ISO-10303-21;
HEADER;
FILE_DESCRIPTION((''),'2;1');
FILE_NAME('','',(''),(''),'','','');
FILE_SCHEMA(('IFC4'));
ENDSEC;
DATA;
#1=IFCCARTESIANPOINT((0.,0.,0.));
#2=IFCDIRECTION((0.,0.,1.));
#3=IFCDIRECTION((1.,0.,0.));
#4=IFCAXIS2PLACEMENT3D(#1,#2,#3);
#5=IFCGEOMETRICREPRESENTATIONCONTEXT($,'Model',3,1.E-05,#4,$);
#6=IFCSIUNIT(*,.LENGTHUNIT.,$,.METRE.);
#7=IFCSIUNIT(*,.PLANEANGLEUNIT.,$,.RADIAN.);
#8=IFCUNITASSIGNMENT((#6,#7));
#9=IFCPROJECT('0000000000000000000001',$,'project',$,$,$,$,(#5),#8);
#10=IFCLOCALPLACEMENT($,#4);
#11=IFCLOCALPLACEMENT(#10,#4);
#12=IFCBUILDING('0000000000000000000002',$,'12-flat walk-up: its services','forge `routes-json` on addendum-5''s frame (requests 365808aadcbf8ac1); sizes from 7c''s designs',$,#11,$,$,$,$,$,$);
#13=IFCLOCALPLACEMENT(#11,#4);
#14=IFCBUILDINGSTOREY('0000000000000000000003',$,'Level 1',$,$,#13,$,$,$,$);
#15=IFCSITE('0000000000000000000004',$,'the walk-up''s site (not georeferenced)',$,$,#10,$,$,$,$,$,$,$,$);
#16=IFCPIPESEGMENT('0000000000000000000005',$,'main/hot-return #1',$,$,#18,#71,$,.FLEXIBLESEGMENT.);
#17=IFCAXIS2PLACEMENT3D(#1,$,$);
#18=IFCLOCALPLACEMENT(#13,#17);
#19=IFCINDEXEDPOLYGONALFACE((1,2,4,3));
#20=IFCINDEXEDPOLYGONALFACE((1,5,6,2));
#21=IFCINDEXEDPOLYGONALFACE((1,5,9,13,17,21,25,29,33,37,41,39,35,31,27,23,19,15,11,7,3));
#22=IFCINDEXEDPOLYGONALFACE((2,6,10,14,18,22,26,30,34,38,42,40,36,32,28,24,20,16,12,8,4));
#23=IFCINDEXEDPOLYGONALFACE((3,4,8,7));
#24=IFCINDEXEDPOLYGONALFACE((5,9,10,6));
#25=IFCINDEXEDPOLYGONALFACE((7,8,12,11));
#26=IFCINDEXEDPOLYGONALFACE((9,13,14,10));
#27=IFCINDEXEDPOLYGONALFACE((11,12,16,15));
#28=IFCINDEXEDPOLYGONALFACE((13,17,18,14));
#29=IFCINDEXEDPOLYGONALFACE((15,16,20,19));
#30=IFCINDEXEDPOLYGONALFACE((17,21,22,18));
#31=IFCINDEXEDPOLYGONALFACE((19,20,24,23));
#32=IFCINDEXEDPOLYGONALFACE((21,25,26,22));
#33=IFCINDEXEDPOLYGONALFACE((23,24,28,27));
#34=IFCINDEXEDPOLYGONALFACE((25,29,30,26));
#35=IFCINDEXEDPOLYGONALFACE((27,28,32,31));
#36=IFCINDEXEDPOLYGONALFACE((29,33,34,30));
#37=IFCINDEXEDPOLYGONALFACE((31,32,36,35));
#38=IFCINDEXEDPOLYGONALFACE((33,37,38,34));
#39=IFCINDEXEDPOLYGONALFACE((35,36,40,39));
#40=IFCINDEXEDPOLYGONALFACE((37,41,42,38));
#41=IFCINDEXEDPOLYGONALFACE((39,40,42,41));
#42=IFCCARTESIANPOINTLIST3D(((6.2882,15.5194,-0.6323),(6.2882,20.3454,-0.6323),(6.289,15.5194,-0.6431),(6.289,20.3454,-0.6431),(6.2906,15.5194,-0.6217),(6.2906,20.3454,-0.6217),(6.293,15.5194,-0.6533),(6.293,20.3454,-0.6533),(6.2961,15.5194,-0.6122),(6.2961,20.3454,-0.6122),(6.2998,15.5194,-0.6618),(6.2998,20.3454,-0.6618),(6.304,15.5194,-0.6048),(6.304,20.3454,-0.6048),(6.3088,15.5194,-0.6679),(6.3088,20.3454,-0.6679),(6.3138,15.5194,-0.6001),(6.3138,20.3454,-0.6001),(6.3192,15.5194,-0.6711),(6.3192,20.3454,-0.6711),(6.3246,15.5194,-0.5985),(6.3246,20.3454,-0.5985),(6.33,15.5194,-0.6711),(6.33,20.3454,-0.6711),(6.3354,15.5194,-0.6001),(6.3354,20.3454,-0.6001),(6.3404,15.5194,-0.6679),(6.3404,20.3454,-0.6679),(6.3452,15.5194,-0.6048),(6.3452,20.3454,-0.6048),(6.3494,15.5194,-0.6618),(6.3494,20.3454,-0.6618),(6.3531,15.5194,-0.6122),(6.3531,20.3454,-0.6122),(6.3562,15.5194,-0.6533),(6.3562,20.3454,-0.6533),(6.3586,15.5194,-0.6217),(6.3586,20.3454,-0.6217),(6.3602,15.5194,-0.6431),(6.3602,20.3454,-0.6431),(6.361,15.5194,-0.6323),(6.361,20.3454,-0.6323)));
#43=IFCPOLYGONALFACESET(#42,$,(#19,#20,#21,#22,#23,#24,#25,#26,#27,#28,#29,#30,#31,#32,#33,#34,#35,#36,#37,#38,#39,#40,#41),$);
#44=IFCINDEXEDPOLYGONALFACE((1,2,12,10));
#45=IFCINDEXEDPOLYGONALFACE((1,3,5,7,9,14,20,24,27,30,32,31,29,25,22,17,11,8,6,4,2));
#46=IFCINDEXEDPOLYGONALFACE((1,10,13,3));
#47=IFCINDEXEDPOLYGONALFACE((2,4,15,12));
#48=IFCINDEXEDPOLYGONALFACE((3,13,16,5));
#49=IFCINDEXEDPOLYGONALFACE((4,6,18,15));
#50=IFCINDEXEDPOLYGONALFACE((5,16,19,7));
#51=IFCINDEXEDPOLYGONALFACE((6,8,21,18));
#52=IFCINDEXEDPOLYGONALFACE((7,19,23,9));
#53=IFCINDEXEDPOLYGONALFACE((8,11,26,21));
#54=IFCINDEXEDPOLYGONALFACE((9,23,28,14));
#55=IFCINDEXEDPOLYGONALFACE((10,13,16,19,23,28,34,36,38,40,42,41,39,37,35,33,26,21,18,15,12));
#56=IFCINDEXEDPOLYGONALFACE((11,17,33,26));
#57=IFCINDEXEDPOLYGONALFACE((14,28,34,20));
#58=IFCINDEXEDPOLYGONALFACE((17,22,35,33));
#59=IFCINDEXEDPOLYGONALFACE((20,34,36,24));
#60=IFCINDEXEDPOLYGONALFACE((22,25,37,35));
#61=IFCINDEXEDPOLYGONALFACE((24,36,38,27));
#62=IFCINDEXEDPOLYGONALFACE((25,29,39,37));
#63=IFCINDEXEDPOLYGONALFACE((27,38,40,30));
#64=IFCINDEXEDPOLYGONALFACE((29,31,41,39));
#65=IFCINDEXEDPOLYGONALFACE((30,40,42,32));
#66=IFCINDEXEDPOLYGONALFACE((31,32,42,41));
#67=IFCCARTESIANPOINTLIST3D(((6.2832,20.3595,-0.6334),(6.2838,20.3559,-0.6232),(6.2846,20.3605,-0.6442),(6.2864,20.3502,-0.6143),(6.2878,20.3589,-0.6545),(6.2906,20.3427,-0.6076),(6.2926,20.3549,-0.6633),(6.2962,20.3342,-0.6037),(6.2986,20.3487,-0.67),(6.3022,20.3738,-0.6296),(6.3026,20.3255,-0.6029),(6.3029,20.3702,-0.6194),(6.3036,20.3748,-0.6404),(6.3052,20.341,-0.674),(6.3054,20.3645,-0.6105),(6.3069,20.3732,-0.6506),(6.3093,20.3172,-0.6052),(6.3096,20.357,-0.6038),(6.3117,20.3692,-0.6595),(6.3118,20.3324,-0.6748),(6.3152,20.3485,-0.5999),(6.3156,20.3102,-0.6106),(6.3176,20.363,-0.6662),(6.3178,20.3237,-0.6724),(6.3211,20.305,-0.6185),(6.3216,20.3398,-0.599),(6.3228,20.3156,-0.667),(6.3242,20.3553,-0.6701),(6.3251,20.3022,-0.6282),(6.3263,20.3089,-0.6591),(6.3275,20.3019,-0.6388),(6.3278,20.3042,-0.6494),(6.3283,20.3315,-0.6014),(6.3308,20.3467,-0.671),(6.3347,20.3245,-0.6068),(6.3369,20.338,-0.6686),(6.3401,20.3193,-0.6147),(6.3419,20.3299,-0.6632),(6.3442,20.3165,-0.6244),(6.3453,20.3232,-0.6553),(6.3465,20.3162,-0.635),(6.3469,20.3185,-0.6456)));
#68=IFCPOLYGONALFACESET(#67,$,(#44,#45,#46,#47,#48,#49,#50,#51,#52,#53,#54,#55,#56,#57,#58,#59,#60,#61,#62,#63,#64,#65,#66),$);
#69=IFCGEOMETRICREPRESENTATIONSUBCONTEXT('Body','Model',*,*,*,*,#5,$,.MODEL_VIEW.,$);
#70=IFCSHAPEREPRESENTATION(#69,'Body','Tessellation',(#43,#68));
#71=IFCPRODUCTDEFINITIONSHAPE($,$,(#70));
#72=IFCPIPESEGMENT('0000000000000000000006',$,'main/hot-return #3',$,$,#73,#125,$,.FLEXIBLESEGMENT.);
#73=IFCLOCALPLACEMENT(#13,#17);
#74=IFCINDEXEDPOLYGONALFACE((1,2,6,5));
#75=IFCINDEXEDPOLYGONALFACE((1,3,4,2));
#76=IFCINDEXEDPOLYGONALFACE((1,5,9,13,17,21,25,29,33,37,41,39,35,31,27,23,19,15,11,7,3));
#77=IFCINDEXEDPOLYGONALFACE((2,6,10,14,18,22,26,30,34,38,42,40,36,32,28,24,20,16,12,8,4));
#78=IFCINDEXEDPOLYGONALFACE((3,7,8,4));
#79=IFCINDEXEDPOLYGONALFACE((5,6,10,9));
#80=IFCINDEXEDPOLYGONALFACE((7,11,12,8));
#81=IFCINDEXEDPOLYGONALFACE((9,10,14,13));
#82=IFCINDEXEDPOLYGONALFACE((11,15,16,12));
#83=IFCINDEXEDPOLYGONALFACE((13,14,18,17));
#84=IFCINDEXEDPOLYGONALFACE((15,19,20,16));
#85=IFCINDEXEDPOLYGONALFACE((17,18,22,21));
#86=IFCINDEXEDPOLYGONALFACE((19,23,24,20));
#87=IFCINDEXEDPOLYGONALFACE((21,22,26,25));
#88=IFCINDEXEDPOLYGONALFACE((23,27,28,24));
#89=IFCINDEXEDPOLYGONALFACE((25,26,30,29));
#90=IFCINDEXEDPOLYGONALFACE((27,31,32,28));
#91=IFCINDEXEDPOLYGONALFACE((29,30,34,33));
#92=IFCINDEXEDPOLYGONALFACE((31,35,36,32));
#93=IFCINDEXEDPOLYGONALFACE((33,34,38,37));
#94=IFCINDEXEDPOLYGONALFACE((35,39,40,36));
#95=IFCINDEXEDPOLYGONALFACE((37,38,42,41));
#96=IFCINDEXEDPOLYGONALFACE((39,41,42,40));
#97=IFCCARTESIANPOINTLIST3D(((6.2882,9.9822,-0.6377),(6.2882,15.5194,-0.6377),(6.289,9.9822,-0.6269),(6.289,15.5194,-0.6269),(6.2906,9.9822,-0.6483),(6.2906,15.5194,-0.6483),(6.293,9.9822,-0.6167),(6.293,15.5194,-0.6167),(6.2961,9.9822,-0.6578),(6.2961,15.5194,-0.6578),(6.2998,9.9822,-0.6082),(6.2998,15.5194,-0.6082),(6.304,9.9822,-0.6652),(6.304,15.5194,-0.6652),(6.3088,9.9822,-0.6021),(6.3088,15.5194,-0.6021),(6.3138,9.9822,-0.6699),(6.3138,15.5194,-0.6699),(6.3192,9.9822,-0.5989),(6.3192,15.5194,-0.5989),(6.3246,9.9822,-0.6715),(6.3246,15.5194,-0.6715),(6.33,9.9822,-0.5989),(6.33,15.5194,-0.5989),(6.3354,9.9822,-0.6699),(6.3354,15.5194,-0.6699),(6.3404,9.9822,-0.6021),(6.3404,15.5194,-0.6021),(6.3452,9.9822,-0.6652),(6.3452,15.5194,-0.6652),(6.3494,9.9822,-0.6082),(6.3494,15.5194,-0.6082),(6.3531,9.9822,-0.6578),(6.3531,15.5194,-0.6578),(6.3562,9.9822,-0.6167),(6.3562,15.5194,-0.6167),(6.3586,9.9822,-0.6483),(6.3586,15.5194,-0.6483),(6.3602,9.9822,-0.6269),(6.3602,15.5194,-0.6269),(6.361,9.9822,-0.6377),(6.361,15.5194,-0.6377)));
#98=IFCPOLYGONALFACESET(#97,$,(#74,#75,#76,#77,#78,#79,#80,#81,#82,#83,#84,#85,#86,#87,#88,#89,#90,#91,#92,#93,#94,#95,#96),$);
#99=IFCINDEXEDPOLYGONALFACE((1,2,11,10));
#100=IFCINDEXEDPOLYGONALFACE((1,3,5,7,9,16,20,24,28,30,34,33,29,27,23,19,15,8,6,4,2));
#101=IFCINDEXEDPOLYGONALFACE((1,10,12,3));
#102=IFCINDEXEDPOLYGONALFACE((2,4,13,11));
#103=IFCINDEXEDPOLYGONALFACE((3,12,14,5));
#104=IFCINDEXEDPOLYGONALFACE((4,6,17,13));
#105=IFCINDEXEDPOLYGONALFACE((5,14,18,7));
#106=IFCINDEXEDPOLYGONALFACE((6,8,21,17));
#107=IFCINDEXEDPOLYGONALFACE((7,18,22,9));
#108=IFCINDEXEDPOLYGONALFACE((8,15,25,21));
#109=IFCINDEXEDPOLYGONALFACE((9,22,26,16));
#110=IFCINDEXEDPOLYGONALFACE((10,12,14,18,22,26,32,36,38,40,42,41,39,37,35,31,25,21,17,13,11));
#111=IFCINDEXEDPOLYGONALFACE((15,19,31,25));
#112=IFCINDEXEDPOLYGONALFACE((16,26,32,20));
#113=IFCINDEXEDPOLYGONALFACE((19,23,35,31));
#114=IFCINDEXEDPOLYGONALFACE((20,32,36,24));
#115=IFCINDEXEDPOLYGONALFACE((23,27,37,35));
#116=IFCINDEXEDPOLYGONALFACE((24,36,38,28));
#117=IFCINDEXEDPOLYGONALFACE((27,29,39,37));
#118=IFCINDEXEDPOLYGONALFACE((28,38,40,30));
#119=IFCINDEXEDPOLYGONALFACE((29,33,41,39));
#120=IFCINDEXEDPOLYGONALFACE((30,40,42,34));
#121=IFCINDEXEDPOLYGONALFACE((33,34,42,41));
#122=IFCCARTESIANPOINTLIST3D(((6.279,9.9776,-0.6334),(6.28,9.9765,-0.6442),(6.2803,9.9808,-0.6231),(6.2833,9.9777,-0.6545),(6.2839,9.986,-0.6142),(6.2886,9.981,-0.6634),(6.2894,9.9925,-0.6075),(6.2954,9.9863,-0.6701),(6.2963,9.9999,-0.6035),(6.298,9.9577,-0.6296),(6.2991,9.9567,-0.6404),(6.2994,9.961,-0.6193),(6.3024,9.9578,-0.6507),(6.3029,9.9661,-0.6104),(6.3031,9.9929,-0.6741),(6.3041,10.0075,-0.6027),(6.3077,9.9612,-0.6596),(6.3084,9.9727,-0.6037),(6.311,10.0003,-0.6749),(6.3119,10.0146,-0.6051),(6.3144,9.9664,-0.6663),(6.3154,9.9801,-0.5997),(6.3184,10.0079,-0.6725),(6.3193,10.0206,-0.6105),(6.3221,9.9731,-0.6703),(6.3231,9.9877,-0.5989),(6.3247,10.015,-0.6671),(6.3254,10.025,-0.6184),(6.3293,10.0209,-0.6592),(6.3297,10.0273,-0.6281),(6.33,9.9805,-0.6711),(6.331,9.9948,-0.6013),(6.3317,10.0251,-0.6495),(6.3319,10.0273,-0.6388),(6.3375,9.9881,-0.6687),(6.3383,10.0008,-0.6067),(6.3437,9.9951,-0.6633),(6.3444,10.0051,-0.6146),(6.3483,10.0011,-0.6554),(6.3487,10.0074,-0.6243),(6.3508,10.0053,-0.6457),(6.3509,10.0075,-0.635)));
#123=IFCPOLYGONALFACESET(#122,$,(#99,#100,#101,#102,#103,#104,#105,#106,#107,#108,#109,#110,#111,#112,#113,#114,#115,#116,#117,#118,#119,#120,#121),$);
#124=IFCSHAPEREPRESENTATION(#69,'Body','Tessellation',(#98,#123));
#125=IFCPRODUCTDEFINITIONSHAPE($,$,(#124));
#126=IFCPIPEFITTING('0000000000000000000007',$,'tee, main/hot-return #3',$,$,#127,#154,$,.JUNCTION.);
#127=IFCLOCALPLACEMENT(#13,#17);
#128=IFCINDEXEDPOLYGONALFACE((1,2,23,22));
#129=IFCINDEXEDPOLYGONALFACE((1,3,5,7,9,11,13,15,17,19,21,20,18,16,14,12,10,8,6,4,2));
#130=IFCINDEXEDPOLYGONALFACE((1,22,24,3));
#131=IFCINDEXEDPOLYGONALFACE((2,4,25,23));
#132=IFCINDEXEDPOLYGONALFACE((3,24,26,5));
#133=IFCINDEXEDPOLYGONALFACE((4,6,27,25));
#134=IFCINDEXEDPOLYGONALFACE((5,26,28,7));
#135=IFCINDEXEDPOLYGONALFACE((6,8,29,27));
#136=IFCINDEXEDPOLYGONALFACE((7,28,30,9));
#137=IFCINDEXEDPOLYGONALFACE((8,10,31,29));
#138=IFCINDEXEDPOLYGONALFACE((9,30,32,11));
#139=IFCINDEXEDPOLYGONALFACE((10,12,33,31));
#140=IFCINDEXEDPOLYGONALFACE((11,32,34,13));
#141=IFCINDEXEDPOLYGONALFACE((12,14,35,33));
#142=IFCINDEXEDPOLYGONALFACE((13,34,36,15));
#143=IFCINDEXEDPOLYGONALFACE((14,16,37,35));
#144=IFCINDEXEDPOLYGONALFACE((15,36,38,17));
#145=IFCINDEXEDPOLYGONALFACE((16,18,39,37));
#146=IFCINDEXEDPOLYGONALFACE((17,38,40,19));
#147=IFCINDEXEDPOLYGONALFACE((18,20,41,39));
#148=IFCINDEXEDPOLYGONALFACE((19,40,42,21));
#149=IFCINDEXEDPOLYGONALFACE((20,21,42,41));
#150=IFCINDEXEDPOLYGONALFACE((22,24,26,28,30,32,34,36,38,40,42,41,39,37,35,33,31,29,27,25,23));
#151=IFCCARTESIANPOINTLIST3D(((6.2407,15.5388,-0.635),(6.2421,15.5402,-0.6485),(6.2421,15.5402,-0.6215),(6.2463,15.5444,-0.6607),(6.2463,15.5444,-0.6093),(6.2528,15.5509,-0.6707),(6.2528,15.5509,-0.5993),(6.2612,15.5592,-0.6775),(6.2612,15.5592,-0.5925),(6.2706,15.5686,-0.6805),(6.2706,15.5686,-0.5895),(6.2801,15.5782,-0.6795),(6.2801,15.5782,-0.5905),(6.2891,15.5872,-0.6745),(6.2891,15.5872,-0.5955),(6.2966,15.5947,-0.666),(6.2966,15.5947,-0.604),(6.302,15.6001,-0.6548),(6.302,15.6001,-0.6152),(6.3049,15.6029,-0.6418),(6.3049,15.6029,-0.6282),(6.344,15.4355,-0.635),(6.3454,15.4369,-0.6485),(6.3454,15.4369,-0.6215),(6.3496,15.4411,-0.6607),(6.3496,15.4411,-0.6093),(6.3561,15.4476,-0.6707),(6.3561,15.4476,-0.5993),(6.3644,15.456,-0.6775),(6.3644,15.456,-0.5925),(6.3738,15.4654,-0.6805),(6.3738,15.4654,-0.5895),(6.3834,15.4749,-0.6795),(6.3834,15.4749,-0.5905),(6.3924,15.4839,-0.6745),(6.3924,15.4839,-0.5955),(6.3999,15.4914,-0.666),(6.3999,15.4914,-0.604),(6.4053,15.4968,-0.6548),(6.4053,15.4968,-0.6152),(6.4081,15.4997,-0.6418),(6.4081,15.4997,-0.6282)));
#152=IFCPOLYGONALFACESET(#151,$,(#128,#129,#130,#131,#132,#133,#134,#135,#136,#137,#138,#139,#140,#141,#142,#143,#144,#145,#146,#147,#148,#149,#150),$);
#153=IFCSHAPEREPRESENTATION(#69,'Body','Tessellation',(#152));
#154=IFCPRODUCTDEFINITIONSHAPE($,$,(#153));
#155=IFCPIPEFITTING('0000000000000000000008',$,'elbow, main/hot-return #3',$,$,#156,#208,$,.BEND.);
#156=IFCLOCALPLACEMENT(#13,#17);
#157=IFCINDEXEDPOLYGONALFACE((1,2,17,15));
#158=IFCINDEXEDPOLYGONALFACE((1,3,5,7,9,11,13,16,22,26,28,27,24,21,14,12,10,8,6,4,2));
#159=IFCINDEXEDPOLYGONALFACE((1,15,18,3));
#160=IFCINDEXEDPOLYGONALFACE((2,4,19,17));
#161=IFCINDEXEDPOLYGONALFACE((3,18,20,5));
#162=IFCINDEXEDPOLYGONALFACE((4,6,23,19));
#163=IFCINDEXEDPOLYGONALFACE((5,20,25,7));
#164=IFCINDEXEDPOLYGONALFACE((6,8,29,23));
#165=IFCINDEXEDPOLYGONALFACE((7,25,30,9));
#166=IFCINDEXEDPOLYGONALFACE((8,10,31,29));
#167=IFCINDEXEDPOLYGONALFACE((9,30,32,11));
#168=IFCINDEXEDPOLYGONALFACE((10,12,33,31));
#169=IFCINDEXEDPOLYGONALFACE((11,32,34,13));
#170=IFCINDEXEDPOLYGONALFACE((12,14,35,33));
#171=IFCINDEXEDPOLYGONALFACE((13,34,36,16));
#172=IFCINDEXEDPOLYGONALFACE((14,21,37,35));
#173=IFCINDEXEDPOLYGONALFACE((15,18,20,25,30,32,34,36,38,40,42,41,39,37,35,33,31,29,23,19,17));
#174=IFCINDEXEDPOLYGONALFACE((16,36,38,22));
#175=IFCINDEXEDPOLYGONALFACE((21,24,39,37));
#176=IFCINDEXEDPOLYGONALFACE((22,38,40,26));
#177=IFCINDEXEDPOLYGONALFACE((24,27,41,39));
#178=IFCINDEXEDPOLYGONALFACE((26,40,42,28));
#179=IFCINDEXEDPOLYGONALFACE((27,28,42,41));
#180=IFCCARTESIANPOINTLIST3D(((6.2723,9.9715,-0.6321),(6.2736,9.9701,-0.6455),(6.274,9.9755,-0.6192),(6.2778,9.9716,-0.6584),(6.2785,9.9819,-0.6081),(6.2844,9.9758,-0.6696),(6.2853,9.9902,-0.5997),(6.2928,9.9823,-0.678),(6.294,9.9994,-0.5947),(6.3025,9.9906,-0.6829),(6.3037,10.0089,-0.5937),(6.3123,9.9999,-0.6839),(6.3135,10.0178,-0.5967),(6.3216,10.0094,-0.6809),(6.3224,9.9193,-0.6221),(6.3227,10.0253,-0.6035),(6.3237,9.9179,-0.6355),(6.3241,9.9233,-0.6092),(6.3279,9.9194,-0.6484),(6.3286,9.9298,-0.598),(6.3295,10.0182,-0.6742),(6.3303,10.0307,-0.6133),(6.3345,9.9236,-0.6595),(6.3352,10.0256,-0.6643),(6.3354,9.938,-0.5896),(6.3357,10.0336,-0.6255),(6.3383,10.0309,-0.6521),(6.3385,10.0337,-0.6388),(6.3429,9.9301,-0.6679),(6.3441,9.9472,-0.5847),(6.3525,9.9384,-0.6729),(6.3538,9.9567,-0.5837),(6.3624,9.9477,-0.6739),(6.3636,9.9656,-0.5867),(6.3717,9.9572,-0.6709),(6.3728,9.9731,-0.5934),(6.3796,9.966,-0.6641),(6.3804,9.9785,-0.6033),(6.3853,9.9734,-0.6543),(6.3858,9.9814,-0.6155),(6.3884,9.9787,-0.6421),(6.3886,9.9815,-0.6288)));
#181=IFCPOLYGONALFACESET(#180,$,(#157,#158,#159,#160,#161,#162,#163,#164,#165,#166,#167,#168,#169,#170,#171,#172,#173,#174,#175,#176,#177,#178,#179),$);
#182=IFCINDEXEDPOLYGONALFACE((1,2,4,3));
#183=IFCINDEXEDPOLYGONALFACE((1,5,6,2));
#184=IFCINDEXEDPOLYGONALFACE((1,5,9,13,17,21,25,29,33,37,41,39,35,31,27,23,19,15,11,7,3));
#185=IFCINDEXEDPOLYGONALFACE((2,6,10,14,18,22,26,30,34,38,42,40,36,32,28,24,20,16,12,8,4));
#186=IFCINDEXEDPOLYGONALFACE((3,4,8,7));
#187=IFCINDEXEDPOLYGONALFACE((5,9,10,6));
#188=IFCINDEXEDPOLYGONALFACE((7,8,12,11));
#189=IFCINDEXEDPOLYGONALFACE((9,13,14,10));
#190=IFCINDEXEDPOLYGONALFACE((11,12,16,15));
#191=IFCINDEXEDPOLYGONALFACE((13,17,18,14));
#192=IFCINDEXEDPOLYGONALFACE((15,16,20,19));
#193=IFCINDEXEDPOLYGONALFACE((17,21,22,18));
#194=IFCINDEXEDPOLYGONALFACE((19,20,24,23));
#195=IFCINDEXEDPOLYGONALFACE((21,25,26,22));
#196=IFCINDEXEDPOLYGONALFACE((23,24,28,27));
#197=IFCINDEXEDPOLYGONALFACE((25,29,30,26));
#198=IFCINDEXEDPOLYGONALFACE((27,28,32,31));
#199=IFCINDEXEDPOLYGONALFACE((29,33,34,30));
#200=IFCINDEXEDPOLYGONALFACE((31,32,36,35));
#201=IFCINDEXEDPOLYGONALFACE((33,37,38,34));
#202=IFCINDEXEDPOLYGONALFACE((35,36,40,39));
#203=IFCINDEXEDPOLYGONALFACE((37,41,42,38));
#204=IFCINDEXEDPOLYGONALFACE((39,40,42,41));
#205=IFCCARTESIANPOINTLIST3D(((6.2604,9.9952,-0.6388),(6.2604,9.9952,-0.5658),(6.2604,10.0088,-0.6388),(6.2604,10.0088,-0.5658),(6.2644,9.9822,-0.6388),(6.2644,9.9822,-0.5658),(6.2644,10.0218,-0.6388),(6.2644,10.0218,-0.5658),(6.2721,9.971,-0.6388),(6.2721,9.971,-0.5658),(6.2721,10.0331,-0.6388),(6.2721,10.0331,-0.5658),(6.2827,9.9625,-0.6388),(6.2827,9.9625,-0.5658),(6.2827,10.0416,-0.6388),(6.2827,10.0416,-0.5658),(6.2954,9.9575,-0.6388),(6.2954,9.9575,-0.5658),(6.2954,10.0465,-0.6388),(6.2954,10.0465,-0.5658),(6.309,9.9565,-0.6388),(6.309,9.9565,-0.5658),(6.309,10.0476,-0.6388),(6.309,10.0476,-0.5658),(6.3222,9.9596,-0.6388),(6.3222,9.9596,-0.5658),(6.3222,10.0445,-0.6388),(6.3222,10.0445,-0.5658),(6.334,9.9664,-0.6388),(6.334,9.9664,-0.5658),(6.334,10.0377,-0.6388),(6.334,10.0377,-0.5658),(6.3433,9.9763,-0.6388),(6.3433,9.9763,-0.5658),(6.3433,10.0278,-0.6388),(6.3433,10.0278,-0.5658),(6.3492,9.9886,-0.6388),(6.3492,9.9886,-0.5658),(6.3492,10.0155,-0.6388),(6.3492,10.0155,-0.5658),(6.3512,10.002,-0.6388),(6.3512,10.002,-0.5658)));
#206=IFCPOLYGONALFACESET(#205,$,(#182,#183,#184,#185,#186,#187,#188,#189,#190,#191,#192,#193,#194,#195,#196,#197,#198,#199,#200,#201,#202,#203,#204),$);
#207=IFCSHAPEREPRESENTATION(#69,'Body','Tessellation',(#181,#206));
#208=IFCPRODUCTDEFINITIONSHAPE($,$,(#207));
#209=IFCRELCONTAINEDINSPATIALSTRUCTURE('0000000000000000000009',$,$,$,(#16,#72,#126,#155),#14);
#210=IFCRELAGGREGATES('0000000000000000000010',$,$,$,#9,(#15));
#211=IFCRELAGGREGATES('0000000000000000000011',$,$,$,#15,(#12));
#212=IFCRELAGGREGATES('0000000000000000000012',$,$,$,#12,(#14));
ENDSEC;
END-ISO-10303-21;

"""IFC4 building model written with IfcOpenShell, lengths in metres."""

from ifc_helpers import new_model, entity, si_unit, frame, origin_with_axes, place, context, subcontext, project, spatial, element, save


model = new_model("IFC4")

# Units and contexts
model_context = context("Model", 3, precision=1e-05, world=origin_with_axes())
body_context = subcontext(model_context, "Body", "Model", "MODEL_VIEW")
ifc_project = project(units=[si_unit("LENGTHUNIT", "METRE"), si_unit("PLANEANGLEUNIT", "RADIAN")], contexts=[model_context])

# Site, building, storey
site_placement = place(None, origin_with_axes())
site = spatial("IfcSite", under=ifc_project, at=site_placement, Name="the walk-up's site (not georeferenced)")
building_placement = place(site_placement, origin_with_axes())
building = spatial("IfcBuilding", under=site, at=building_placement, Name="12-flat walk-up: its services", Description="forge `routes-json` on addendum-5's frame (requests 365808aadcbf8ac1); sizes from 7c's designs")
storey_placement = place(building_placement, origin_with_axes())
storey = spatial("IfcBuildingStorey", under=building, at=storey_placement, Name="Level 1")

# Pipe segments
pipe_segment_1_placement = place(storey_placement, frame((6.3246, 15.5194, -0.635), z_axis=(0.0, 0.0, 1.0), x_axis=(1.0, 0.0, 0.0)))
element("IfcPipeSegment", 1, at=pipe_segment_1_placement, inside=storey, Name="main/hot-return #1", PredefinedType="FLEXIBLESEGMENT", context=body_context, shape_type="AdvancedSweptSolid", body=[
    entity("IfcSweptDiskSolid", entity("IfcPolyline", [entity("IfcCartesianPoint", [0.0, 0.0, 0.0]), entity("IfcCartesianPoint", [0.0, 4.826, 0.0])]), 0.0365),
    entity("IfcSweptDiskSolid", entity("IfcPolyline", [entity("IfcCartesianPoint", [0.0, 4.826, 0.0]), entity("IfcCartesianPoint", [-0.019, 4.8117, -0.0038])]), 0.0365),
])
pipe_segment_2_placement = place(storey_placement, frame((6.3246, 15.5194, -0.635), z_axis=(0.0, 0.0, 1.0), x_axis=(1.0, 0.0, 0.0)))
element("IfcPipeSegment", 2, at=pipe_segment_2_placement, inside=storey, Name="main/hot-return #3", PredefinedType="FLEXIBLESEGMENT", context=body_context, shape_type="AdvancedSweptSolid", body=[
    entity("IfcSweptDiskSolid", entity("IfcPolyline", [entity("IfcCartesianPoint", [0.0, 0.0, 0.0]), entity("IfcCartesianPoint", [0.0, -5.5372, 0.0])]), 0.0365),
    entity("IfcSweptDiskSolid", entity("IfcPolyline", [entity("IfcCartesianPoint", [0.0, -5.5372, 0.0]), entity("IfcCartesianPoint", [-0.019, -5.5174, -0.0038])]), 0.0365),
])

# Pipe fittings
pipe_fitting_1_placement = place(storey_placement, frame((6.3762, 15.4678, -0.635), z_axis=(0.0, 0.0, 1.0), x_axis=(1.0, 0.0, 0.0)))
element("IfcPipeFitting", 3, at=pipe_fitting_1_placement, inside=storey, Name="tee, main/hot-return #3", PredefinedType="JUNCTION", context=body_context, shape_type="AdvancedSweptSolid", body=[
    entity("IfcSweptDiskSolid", entity("IfcPolyline", [entity("IfcCartesianPoint", [0.0, 0.0, 0.0]), entity("IfcCartesianPoint", [-0.1033, 0.1033, 0.0])]), 0.0456),
])
pipe_fitting_2_placement = place(storey_placement, frame((6.3556, 9.9499, -0.6288), z_axis=(0.0, 0.0, 1.0), x_axis=(1.0, 0.0, 0.0)))
element("IfcPipeFitting", 4, at=pipe_fitting_2_placement, inside=storey, Name="elbow, main/hot-return #3", PredefinedType="BEND", context=body_context, shape_type="AdvancedSweptSolid", body=[
    entity("IfcSweptDiskSolid", entity("IfcPolyline", [entity("IfcCartesianPoint", [0.0, 0.0, 0.0]), entity("IfcCartesianPoint", [-0.0501, 0.0522, -0.01])]), 0.0456),
    entity("IfcSweptDiskSolid", entity("IfcPolyline", [entity("IfcCartesianPoint", [-0.0501, 0.0522, -0.01]), entity("IfcCartesianPoint", [-0.0501, 0.0522, 0.063])]), 0.0456),
])

save(model, "model.ifc")
